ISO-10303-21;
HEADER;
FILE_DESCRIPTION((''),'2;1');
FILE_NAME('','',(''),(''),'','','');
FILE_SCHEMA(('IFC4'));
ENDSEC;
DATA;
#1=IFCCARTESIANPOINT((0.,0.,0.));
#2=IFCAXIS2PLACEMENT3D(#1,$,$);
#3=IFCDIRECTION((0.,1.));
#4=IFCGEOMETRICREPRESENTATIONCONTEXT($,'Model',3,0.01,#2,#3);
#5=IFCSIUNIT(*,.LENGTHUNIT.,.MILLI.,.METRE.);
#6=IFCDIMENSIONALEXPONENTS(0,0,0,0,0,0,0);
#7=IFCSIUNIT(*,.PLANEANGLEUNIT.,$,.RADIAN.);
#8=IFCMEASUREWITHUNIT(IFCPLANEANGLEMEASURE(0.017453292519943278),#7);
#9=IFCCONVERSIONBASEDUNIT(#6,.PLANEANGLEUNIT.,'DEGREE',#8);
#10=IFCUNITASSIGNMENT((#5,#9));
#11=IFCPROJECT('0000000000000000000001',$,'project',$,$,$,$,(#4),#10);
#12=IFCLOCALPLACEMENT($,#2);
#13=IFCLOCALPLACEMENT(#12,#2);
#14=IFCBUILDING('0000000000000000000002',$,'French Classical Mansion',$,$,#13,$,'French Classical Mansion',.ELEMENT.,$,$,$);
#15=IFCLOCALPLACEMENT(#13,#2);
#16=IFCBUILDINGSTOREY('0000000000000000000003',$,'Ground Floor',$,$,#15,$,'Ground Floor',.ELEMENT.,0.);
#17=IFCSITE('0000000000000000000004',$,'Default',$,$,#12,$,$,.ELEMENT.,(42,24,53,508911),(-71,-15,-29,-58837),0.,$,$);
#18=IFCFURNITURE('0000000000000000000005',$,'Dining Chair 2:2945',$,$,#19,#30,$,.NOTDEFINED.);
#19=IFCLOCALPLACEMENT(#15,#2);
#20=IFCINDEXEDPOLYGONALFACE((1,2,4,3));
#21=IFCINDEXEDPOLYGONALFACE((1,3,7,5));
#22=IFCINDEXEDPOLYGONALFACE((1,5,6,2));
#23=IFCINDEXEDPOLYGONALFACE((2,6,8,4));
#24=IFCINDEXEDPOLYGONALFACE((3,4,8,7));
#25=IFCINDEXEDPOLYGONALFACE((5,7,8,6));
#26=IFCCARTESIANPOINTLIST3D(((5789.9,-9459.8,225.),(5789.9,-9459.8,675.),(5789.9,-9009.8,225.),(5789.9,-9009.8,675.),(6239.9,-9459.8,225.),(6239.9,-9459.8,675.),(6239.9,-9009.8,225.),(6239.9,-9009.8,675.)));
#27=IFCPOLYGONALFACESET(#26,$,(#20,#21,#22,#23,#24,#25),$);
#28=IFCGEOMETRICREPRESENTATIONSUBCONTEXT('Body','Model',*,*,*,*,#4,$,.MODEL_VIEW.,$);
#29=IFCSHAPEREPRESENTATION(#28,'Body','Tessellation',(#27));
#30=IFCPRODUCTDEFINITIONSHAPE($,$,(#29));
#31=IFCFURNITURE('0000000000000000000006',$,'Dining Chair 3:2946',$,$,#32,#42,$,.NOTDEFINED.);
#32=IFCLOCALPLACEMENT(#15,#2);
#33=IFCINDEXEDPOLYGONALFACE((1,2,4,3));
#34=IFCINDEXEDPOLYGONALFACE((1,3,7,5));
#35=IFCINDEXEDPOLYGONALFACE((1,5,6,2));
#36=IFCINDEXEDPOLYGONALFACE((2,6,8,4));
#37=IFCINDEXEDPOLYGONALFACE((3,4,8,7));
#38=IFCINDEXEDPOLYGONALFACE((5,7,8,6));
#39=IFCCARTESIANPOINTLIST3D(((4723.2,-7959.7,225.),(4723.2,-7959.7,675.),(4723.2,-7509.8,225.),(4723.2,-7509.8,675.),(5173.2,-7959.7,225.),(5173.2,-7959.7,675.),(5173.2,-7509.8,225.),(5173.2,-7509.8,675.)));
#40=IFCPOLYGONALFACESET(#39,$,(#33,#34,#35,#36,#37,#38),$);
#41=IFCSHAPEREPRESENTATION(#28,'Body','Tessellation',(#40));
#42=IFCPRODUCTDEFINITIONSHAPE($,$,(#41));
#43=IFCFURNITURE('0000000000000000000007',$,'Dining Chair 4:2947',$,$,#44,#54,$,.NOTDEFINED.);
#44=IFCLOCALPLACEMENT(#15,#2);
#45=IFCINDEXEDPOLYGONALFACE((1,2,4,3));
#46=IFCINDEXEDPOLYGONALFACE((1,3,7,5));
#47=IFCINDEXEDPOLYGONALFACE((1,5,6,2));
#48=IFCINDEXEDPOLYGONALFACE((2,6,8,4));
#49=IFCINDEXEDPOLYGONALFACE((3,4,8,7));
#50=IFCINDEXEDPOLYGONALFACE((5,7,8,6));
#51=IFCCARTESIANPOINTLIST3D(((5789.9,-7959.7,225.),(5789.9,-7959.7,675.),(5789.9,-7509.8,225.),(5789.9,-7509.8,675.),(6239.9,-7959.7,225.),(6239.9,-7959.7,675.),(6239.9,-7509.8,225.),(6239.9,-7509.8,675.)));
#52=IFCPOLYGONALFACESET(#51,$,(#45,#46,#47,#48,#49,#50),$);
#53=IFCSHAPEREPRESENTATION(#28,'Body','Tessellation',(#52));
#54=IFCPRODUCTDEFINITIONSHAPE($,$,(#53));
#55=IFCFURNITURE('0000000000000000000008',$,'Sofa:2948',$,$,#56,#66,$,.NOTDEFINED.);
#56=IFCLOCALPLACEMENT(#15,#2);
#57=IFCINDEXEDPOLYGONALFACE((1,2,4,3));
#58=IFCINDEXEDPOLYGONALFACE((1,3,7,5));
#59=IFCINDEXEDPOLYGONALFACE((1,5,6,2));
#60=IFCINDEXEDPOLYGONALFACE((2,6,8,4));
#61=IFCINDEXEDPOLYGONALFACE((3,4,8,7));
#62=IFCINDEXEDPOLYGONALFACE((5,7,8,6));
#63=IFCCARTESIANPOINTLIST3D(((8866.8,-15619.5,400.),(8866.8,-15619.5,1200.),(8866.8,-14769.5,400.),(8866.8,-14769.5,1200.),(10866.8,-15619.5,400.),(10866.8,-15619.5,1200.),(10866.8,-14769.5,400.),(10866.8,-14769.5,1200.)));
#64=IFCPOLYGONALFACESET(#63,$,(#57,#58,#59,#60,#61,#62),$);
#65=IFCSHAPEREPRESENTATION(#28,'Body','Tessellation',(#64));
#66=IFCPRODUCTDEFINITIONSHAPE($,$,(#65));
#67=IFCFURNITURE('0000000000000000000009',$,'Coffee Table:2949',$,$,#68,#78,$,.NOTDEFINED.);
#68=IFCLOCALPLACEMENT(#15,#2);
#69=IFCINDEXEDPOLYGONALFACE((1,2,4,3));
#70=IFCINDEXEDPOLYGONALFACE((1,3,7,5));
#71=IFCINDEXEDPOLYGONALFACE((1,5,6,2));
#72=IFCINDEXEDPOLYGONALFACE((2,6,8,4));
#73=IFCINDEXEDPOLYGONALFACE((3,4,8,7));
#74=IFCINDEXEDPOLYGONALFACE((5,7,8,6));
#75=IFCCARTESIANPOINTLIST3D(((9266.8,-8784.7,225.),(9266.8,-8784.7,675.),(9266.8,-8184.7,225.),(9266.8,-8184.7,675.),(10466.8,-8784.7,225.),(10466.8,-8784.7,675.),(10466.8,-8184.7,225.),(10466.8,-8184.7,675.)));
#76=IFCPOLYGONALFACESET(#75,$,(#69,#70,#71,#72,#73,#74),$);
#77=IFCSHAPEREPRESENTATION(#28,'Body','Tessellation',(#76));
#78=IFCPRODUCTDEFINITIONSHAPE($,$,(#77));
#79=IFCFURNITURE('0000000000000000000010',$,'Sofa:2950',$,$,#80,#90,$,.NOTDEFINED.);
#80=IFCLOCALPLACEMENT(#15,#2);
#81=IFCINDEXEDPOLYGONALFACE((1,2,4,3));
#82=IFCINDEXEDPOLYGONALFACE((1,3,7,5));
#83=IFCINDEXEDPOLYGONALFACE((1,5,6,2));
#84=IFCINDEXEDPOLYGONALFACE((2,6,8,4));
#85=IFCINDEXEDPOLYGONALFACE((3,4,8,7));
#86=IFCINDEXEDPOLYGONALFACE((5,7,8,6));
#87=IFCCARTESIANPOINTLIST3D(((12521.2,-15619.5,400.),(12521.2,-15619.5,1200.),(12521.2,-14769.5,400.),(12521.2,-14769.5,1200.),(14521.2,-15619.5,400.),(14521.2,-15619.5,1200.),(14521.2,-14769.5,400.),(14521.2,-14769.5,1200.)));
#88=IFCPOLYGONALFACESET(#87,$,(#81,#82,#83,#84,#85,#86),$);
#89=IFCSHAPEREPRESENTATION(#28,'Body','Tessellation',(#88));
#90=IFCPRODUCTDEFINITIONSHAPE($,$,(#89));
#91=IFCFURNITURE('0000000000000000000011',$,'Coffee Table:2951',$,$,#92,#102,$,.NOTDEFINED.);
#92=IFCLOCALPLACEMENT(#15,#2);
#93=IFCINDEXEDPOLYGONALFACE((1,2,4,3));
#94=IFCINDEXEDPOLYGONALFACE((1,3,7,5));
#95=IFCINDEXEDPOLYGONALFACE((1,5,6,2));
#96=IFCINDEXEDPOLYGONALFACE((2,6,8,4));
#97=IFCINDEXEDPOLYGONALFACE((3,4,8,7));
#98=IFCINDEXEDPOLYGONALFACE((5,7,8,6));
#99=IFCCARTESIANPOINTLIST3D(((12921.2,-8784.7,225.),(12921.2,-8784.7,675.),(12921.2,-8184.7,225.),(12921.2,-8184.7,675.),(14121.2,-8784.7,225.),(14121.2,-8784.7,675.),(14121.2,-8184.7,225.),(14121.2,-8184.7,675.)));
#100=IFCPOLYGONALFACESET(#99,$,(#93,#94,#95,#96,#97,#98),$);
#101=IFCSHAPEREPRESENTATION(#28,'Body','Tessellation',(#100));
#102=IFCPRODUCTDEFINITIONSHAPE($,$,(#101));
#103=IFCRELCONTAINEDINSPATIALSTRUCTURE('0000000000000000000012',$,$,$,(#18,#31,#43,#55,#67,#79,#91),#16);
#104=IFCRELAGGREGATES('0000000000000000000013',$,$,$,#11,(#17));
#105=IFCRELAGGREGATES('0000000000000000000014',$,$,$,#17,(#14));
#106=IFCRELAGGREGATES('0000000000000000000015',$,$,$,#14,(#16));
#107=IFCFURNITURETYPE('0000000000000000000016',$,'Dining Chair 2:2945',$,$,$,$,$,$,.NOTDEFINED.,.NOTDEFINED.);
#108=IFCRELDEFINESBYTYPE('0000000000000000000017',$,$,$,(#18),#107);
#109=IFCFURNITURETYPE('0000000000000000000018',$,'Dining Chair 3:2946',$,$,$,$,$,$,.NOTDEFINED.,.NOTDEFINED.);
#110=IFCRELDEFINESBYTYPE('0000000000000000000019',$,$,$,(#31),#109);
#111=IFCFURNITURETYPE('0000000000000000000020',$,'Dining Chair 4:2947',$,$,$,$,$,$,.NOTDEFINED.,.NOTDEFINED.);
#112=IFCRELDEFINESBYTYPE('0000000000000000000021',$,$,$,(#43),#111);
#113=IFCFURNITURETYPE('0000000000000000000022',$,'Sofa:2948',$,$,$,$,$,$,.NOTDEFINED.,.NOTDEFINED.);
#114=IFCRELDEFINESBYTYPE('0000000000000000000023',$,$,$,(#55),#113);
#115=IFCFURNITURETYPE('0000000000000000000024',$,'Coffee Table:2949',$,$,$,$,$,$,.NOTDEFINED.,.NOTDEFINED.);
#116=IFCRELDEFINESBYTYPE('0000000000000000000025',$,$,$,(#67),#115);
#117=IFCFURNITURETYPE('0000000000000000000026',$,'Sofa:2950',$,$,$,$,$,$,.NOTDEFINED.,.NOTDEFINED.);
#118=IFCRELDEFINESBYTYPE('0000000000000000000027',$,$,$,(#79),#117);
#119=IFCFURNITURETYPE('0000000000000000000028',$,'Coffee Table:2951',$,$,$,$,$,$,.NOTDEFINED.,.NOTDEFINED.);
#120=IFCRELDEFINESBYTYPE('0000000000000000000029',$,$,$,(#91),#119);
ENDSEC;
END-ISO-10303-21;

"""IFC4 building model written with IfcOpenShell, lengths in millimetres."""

from ifc_helpers import new_model, entity, si_unit, converted_unit, direction, frame, frame_2d, origin, origin_2d_with_axis, place, context, subcontext, project, spatial, rectangle, extrude, type_object, element, save


model = new_model("IFC4")

# Units and contexts
model_context = context("Model", 3, precision=0.01, world=origin(), true_north=direction((0.0, 1.0)))
body_context = subcontext(model_context, "Body", "Model", "MODEL_VIEW")
ifc_project = project(units=[si_unit("LENGTHUNIT", "METRE", prefix="MILLI"), converted_unit("PLANEANGLEUNIT", "DEGREE", entity("IfcPlaneAngleMeasure", 0.017453292519943278), si_unit("PLANEANGLEUNIT", "RADIAN"), dimensions=[0, 0, 0, 0, 0, 0, 0])], contexts=[model_context])

# Site, building, storey
site_placement = place(None, origin())
site = spatial("IfcSite", under=ifc_project, at=site_placement, Name="Default", CompositionType="ELEMENT", RefLatitude=(42, 24, 53, 508911), RefLongitude=(-71, -15, -29, -58837), RefElevation=0.0)
building_placement = place(site_placement, origin())
building = spatial("IfcBuilding", under=site, at=building_placement, Name="French Classical Mansion", LongName="French Classical Mansion", CompositionType="ELEMENT")
storey_placement = place(building_placement, origin())
storey = spatial("IfcBuildingStorey", under=building, at=storey_placement, Name="Ground Floor", LongName="Ground Floor", CompositionType="ELEMENT", Elevation=0.0)

# Furniture
furniture_type_1 = type_object("IfcFurnitureType", Name="Dining Chair 2:2945", PredefinedType="NOTDEFINED")
furniture_1_placement = place(storey_placement, origin())
element("IfcFurniture", 1, at=furniture_1_placement, inside=storey, type_object=furniture_type_1, Name="Dining Chair 2:2945", PredefinedType="NOTDEFINED", context=body_context, shape_type="SweptSolid", body=[
    extrude(rectangle(XDim=450.0, YDim=450.0, at=origin_2d_with_axis()), frame((6014.9, -9234.8, 225.0)), (0.0, 0.0, 1.0), 450.0),
])
furniture_type_2 = type_object("IfcFurnitureType", Name="Dining Chair 3:2946", PredefinedType="NOTDEFINED")
furniture_2_placement = place(storey_placement, origin())
element("IfcFurniture", 2, at=furniture_2_placement, inside=storey, type_object=furniture_type_2, Name="Dining Chair 3:2946", PredefinedType="NOTDEFINED", context=body_context, shape_type="SweptSolid", body=[
    extrude(rectangle(XDim=450.0, YDim=450.0, at=origin_2d_with_axis()), frame((4948.2, -7734.8, 225.0)), (0.0, 0.0, 1.0), 450.0),
])
furniture_type_3 = type_object("IfcFurnitureType", Name="Dining Chair 4:2947", PredefinedType="NOTDEFINED")
furniture_3_placement = place(storey_placement, origin())
element("IfcFurniture", 3, at=furniture_3_placement, inside=storey, type_object=furniture_type_3, Name="Dining Chair 4:2947", PredefinedType="NOTDEFINED", context=body_context, shape_type="SweptSolid", body=[
    extrude(rectangle(XDim=450.0, YDim=450.0, at=origin_2d_with_axis()), frame((6014.9, -7734.8, 225.0)), (0.0, 0.0, 1.0), 450.0),
])
furniture_type_4 = type_object("IfcFurnitureType", Name="Sofa:2948", PredefinedType="NOTDEFINED")
furniture_4_placement = place(storey_placement, origin())
element("IfcFurniture", 4, at=furniture_4_placement, inside=storey, type_object=furniture_type_4, Name="Sofa:2948", PredefinedType="NOTDEFINED", context=body_context, shape_type="SweptSolid", body=[
    extrude(rectangle(XDim=2000.0, YDim=850.0, at=frame_2d((0.0, 0.0), x_axis=(1.0, 0.0))), frame((9866.8, -15194.5, 400.0)), (0.0, 0.0, 1.0), 800.0),
])
furniture_type_5 = type_object("IfcFurnitureType", Name="Coffee Table:2949", PredefinedType="NOTDEFINED")
furniture_5_placement = place(storey_placement, origin())
element("IfcFurniture", 5, at=furniture_5_placement, inside=storey, type_object=furniture_type_5, Name="Coffee Table:2949", PredefinedType="NOTDEFINED", context=body_context, shape_type="SweptSolid", body=[
    extrude(rectangle(XDim=1200.0, YDim=600.0, at=frame_2d((0.0, 0.0), x_axis=(1.0, 0.0))), frame((9866.8, -8484.7, 225.0)), (0.0, 0.0, 1.0), 450.0),
])
furniture_type_6 = type_object("IfcFurnitureType", Name="Sofa:2950", PredefinedType="NOTDEFINED")
furniture_6_placement = place(storey_placement, origin())
element("IfcFurniture", 6, at=furniture_6_placement, inside=storey, type_object=furniture_type_6, Name="Sofa:2950", PredefinedType="NOTDEFINED", context=body_context, shape_type="SweptSolid", body=[
    extrude(rectangle(XDim=2000.0, YDim=850.0, at=frame_2d((0.0, 0.0), x_axis=(1.0, 0.0))), frame((13521.2, -15194.5, 400.0)), (0.0, 0.0, 1.0), 800.0),
])
furniture_type_7 = type_object("IfcFurnitureType", Name="Coffee Table:2951", PredefinedType="NOTDEFINED")
furniture_7_placement = place(storey_placement, origin())
element("IfcFurniture", 7, at=furniture_7_placement, inside=storey, type_object=furniture_type_7, Name="Coffee Table:2951", PredefinedType="NOTDEFINED", context=body_context, shape_type="SweptSolid", body=[
    extrude(rectangle(XDim=1200.0, YDim=600.0, at=frame_2d((0.0, 0.0), x_axis=(1.0, 0.0))), frame((13521.2, -8484.7, 225.0)), (0.0, 0.0, 1.0), 450.0),
])

save(model, "model.ifc")
